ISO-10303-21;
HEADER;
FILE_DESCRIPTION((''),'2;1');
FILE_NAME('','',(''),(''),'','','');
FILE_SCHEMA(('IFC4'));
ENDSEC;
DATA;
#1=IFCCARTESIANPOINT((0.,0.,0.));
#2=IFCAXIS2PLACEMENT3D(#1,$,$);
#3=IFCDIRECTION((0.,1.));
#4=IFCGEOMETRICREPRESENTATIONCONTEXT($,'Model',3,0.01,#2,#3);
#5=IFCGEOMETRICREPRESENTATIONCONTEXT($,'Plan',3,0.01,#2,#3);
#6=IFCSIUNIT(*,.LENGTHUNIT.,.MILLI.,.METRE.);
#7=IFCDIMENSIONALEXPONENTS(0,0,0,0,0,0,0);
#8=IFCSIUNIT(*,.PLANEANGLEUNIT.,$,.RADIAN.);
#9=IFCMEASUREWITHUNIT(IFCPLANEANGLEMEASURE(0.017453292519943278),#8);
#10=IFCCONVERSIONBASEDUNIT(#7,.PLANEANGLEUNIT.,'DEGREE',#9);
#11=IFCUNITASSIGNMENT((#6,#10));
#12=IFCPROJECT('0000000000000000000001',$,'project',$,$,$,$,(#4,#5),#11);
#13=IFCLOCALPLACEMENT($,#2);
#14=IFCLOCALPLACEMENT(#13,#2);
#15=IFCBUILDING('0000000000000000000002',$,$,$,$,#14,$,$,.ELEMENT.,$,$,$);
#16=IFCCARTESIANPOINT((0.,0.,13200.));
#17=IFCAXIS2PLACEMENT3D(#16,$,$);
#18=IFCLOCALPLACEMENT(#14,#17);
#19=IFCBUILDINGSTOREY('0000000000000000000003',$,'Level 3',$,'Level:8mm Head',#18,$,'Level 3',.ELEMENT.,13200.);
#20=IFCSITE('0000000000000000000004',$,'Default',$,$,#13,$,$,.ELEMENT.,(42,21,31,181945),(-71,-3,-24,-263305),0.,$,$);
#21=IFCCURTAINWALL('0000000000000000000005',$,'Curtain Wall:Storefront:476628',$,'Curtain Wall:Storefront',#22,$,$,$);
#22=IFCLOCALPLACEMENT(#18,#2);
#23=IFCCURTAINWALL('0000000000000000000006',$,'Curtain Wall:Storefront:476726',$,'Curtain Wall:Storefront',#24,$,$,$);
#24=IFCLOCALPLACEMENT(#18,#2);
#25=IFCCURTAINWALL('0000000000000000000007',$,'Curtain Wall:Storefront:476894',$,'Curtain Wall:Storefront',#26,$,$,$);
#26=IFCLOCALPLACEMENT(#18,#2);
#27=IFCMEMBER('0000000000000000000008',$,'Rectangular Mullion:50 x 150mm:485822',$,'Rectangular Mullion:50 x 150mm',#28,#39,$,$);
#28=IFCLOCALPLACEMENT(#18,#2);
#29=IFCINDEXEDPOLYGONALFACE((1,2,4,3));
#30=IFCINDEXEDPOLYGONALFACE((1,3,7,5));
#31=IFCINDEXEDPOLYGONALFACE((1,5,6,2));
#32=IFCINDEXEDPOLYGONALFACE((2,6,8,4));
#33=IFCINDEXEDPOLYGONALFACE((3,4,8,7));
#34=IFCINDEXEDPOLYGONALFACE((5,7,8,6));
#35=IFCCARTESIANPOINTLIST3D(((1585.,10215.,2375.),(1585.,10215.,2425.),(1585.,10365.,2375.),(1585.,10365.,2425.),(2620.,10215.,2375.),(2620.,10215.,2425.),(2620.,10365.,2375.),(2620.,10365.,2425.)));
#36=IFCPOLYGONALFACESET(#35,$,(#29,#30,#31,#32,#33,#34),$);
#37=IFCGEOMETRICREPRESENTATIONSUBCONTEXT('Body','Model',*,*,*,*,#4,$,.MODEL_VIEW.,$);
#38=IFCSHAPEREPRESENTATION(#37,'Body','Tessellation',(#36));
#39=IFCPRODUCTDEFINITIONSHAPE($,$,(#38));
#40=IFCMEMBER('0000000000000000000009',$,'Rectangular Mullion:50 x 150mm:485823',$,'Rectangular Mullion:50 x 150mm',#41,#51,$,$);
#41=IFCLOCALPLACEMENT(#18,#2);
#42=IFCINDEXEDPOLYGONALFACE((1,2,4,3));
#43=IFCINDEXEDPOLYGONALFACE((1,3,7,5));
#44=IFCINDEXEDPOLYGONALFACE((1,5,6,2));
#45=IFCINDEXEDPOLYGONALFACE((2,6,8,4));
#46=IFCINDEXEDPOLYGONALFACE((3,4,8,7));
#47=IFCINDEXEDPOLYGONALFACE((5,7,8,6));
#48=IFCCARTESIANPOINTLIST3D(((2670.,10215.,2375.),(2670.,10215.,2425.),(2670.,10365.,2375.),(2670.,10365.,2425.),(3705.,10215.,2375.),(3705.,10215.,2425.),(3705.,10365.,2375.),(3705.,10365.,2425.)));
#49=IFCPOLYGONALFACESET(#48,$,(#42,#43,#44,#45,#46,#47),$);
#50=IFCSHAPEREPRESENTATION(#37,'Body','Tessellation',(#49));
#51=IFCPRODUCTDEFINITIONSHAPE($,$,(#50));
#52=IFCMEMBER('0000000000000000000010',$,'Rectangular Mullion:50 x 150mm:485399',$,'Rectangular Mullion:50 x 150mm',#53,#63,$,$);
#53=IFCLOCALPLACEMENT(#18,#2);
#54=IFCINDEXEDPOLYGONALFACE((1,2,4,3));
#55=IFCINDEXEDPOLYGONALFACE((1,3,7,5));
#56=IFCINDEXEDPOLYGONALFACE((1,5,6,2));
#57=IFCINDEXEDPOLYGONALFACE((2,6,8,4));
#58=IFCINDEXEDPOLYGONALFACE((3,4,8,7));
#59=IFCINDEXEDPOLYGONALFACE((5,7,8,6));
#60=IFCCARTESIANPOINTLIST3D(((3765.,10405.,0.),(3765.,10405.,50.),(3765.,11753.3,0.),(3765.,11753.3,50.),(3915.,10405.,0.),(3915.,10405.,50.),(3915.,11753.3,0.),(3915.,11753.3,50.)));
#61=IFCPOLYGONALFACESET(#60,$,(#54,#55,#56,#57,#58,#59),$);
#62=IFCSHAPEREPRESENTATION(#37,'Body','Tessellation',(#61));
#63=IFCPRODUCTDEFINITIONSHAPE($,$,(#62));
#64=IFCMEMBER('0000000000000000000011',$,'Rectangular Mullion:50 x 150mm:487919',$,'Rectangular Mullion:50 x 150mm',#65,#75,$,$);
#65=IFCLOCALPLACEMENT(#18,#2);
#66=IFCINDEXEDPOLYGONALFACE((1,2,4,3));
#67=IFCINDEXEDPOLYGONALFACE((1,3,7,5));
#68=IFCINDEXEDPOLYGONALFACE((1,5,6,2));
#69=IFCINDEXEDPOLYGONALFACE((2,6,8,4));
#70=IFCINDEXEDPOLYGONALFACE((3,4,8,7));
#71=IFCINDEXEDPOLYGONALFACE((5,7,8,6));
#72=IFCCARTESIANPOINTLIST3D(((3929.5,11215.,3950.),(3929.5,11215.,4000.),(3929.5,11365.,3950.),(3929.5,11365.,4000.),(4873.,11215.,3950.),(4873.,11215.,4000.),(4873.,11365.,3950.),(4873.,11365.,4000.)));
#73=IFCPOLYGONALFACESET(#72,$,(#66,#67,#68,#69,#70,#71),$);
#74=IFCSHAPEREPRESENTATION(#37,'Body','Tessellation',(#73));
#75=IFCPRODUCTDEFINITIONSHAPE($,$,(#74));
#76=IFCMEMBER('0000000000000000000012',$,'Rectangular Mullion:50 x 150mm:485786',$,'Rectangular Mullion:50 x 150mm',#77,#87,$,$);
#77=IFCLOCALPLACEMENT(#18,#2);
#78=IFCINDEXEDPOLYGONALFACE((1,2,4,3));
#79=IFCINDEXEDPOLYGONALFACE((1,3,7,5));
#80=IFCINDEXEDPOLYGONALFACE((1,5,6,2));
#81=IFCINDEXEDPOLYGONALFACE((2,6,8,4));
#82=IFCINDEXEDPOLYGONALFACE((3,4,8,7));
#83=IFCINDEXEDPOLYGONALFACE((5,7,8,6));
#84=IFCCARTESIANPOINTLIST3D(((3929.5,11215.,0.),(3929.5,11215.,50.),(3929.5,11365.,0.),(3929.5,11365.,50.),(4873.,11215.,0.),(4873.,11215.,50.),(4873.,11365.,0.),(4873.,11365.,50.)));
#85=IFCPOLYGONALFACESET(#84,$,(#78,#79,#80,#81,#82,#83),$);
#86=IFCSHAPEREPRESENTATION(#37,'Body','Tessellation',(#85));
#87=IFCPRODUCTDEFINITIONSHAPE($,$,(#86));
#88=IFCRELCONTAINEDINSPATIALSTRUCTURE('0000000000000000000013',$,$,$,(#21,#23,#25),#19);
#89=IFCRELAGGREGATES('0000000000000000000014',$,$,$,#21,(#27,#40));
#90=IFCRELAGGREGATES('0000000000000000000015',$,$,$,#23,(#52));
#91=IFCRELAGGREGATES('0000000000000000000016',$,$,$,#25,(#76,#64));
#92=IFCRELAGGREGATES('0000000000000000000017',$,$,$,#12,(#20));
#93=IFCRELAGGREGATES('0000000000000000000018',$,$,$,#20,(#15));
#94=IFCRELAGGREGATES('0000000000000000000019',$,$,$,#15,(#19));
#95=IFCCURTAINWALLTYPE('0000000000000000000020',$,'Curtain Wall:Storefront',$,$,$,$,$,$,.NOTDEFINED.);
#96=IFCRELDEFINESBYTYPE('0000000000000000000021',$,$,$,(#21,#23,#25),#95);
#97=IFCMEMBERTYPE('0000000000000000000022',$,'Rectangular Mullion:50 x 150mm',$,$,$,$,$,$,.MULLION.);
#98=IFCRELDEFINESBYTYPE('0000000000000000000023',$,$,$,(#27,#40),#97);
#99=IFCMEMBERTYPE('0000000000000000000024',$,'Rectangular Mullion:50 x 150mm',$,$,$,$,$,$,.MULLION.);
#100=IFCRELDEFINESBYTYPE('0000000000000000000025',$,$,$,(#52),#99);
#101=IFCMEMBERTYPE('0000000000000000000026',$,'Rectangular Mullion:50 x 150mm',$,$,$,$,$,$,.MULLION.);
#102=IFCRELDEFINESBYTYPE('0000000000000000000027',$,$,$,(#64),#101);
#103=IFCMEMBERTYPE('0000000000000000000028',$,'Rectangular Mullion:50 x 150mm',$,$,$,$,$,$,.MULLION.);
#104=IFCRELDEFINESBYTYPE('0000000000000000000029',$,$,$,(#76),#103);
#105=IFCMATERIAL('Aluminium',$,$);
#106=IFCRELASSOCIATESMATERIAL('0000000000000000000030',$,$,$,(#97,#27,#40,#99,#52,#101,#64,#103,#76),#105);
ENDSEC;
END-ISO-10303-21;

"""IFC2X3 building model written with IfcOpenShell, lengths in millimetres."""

from ifc_helpers import new_model, entity, si_unit, converted_unit, direction, frame, origin, origin_2d_with_axis, place, context, subcontext, project, spatial, rectangle, extrude, source, transform, mapped, material, type_object, type_shapes, element, aggregate, save


model = new_model("IFC2X3")

# Units and contexts
model_context = context("Model", 3, precision=0.01, world=origin(), true_north=direction((0.0, 1.0)))
plan_context = context("Plan", 3, precision=0.01, world=origin(), true_north=direction((0.0, 1.0)))
body_context = subcontext(model_context, "Body", "Model", "MODEL_VIEW")
ifc_project = project(units=[si_unit("LENGTHUNIT", "METRE", prefix="MILLI"), converted_unit("PLANEANGLEUNIT", "DEGREE", entity("IfcPlaneAngleMeasure", 0.017453292519943278), si_unit("PLANEANGLEUNIT", "RADIAN"), dimensions=[0, 0, 0, 0, 0, 0, 0])], contexts=[model_context, plan_context])

# Site, building, storey
site_placement = place(None, origin())
site = spatial("IfcSite", under=ifc_project, at=site_placement, Name="Default", CompositionType="ELEMENT", RefLatitude=(42, 21, 31, 181945), RefLongitude=(-71, -3, -24, -263305), RefElevation=0.0)
building_placement = place(site_placement, origin())
building = spatial("IfcBuilding", under=site, at=building_placement, CompositionType="ELEMENT")
storey_placement = place(building_placement, frame((0.0, 0.0, 13200.0)))
storey = spatial("IfcBuildingStorey", under=building, at=storey_placement, Name="Level 3", ObjectType="Level:8mm Head", LongName="Level 3", CompositionType="ELEMENT", Elevation=13200.0)

# Curtain walls
curtain_wall_type = type_object("IfcCurtainWallType", Name="Curtain Wall:Storefront", PredefinedType="NOTDEFINED")
curtain_wall_1_placement = place(storey_placement, frame((0.0, 0.0, -13200.0)))
curtain_wall_1 = element("IfcCurtainWall", 1, at=curtain_wall_1_placement, inside=storey, type_object=curtain_wall_type, Name="Curtain Wall:Storefront:476628", ObjectType="Curtain Wall:Storefront")
ifc_material_1 = material(Name="Aluminium")
curtain_wall_2_placement = place(storey_placement, frame((0.0, 0.0, -13200.0)))
curtain_wall_2 = element("IfcCurtainWall", 2, at=curtain_wall_2_placement, inside=storey, type_object=curtain_wall_type, Name="Curtain Wall:Storefront:476726", ObjectType="Curtain Wall:Storefront")
curtain_wall_3_placement = place(storey_placement, frame((0.0, 0.0, -13200.0)))
curtain_wall_3 = element("IfcCurtainWall", 3, at=curtain_wall_3_placement, inside=storey, type_object=curtain_wall_type, Name="Curtain Wall:Storefront:476894", ObjectType="Curtain Wall:Storefront")

# Members
member_type_1 = type_object("IfcMemberType", Name="Rectangular Mullion:50 x 150mm", PredefinedType="MULLION", material=ifc_material_1)
shared_shape_1 = source(origin(), body_context, "Body", "SweptSolid", [
    extrude(rectangle(XDim=50.0, YDim=150.0, at=origin_2d_with_axis()), frame((0.0, 0.0, -1035.0), z_axis=(0.0, 0.0, 1.0), x_axis=(-1.0, 0.0, 0.0)), (0.0, 0.0, 1.0), 1035.0),
])
type_shapes(member_type_1, [shared_shape_1])
member_1_placement = place(curtain_wall_1_placement, frame((2620.0, 10290.0, 15600.0), z_axis=(1.0, 0.0, 0.0), x_axis=(0.0, 0.0, 1.0)))
member_1 = element("IfcMember", 4, at=member_1_placement, type_object=member_type_1, material=ifc_material_1, Name="Rectangular Mullion:50 x 150mm:485822", ObjectType="Rectangular Mullion:50 x 150mm", context=body_context, shape_type="MappedRepresentation", body=[
    mapped(shared_shape_1, transform((0.0, 0.0, 0.0), scale=1.0)),
])
member_2_placement = place(curtain_wall_1_placement, frame((3705.0, 10290.0, 15600.0), z_axis=(1.0, 0.0, 0.0), x_axis=(0.0, 0.0, 1.0)))
member_2 = element("IfcMember", 5, at=member_2_placement, type_object=member_type_1, material=ifc_material_1, Name="Rectangular Mullion:50 x 150mm:485823", ObjectType="Rectangular Mullion:50 x 150mm", context=body_context, shape_type="MappedRepresentation", body=[
    mapped(shared_shape_1, transform((0.0, 0.0, 0.0), scale=1.0)),
])
member_type_2 = type_object("IfcMemberType", Name="Rectangular Mullion:50 x 150mm", PredefinedType="MULLION", material=ifc_material_1)
shared_shape_2 = source(origin(), body_context, "Body", "SweptSolid", [
    extrude(rectangle(XDim=50.0, YDim=150.0, at=origin_2d_with_axis()), frame((-25.0, 0.0, -1348.3), z_axis=(0.0, 0.0, 1.0), x_axis=(-1.0, 0.0, 0.0)), (0.0, 0.0, 1.0), 1348.3),
])
type_shapes(member_type_2, [shared_shape_2])
member_3_placement = place(curtain_wall_2_placement, frame((3840.0, 10405.0, 13200.0), z_axis=(0.0, -1.0, 0.0), x_axis=(0.0, 0.0, -1.0)))
member_3 = element("IfcMember", 6, at=member_3_placement, type_object=member_type_2, material=ifc_material_1, Name="Rectangular Mullion:50 x 150mm:485399", ObjectType="Rectangular Mullion:50 x 150mm", context=body_context, shape_type="MappedRepresentation", body=[
    mapped(shared_shape_2, transform((0.0, 0.0, 0.0), scale=1.0)),
])
member_type_3 = type_object("IfcMemberType", Name="Rectangular Mullion:50 x 150mm", PredefinedType="MULLION", material=ifc_material_1)
shared_shape_3 = source(origin(), body_context, "Body", "SweptSolid", [
    extrude(rectangle(XDim=50.0, YDim=150.0, at=origin_2d_with_axis()), frame((-25.0, 0.0, -943.5), z_axis=(0.0, 0.0, 1.0), x_axis=(-1.0, 0.0, 0.0)), (0.0, 0.0, 1.0), 943.5),
])
type_shapes(member_type_3, [shared_shape_3])
member_4_placement = place(curtain_wall_3_placement, frame((4873.0, 11290.0, 17200.0), z_axis=(1.0, 0.0, 0.0), x_axis=(0.0, 0.0, 1.0)))
member_4 = element("IfcMember", 7, at=member_4_placement, type_object=member_type_3, material=ifc_material_1, Name="Rectangular Mullion:50 x 150mm:487919", ObjectType="Rectangular Mullion:50 x 150mm", context=body_context, shape_type="MappedRepresentation", body=[
    mapped(shared_shape_3, transform((0.0, 0.0, 0.0), scale=1.0)),
])
member_type_4 = type_object("IfcMemberType", Name="Rectangular Mullion:50 x 150mm", PredefinedType="MULLION", material=ifc_material_1)
shared_shape_4 = source(origin(), body_context, "Body", "SweptSolid", [
    extrude(rectangle(XDim=50.0, YDim=150.0, at=origin_2d_with_axis()), frame((-25.0, 0.0, -943.5), z_axis=(0.0, 0.0, 1.0), x_axis=(-1.0, 0.0, 0.0)), (0.0, 0.0, 1.0), 943.5),
])
type_shapes(member_type_4, [shared_shape_4])
member_5_placement = place(curtain_wall_3_placement, frame((3929.5, 11290.0, 13200.0), z_axis=(-1.0, 0.0, 0.0), x_axis=(0.0, 0.0, -1.0)))
member_5 = element("IfcMember", 8, at=member_5_placement, type_object=member_type_4, material=ifc_material_1, Name="Rectangular Mullion:50 x 150mm:485786", ObjectType="Rectangular Mullion:50 x 150mm", context=body_context, shape_type="MappedRepresentation", body=[
    mapped(shared_shape_4, transform((0.0, 0.0, 0.0), scale=1.0)),
])

aggregate(curtain_wall_1, [member_1, member_2])
aggregate(curtain_wall_2, [member_3])
aggregate(curtain_wall_3, [member_5, member_4])

save(model, "model.ifc")
